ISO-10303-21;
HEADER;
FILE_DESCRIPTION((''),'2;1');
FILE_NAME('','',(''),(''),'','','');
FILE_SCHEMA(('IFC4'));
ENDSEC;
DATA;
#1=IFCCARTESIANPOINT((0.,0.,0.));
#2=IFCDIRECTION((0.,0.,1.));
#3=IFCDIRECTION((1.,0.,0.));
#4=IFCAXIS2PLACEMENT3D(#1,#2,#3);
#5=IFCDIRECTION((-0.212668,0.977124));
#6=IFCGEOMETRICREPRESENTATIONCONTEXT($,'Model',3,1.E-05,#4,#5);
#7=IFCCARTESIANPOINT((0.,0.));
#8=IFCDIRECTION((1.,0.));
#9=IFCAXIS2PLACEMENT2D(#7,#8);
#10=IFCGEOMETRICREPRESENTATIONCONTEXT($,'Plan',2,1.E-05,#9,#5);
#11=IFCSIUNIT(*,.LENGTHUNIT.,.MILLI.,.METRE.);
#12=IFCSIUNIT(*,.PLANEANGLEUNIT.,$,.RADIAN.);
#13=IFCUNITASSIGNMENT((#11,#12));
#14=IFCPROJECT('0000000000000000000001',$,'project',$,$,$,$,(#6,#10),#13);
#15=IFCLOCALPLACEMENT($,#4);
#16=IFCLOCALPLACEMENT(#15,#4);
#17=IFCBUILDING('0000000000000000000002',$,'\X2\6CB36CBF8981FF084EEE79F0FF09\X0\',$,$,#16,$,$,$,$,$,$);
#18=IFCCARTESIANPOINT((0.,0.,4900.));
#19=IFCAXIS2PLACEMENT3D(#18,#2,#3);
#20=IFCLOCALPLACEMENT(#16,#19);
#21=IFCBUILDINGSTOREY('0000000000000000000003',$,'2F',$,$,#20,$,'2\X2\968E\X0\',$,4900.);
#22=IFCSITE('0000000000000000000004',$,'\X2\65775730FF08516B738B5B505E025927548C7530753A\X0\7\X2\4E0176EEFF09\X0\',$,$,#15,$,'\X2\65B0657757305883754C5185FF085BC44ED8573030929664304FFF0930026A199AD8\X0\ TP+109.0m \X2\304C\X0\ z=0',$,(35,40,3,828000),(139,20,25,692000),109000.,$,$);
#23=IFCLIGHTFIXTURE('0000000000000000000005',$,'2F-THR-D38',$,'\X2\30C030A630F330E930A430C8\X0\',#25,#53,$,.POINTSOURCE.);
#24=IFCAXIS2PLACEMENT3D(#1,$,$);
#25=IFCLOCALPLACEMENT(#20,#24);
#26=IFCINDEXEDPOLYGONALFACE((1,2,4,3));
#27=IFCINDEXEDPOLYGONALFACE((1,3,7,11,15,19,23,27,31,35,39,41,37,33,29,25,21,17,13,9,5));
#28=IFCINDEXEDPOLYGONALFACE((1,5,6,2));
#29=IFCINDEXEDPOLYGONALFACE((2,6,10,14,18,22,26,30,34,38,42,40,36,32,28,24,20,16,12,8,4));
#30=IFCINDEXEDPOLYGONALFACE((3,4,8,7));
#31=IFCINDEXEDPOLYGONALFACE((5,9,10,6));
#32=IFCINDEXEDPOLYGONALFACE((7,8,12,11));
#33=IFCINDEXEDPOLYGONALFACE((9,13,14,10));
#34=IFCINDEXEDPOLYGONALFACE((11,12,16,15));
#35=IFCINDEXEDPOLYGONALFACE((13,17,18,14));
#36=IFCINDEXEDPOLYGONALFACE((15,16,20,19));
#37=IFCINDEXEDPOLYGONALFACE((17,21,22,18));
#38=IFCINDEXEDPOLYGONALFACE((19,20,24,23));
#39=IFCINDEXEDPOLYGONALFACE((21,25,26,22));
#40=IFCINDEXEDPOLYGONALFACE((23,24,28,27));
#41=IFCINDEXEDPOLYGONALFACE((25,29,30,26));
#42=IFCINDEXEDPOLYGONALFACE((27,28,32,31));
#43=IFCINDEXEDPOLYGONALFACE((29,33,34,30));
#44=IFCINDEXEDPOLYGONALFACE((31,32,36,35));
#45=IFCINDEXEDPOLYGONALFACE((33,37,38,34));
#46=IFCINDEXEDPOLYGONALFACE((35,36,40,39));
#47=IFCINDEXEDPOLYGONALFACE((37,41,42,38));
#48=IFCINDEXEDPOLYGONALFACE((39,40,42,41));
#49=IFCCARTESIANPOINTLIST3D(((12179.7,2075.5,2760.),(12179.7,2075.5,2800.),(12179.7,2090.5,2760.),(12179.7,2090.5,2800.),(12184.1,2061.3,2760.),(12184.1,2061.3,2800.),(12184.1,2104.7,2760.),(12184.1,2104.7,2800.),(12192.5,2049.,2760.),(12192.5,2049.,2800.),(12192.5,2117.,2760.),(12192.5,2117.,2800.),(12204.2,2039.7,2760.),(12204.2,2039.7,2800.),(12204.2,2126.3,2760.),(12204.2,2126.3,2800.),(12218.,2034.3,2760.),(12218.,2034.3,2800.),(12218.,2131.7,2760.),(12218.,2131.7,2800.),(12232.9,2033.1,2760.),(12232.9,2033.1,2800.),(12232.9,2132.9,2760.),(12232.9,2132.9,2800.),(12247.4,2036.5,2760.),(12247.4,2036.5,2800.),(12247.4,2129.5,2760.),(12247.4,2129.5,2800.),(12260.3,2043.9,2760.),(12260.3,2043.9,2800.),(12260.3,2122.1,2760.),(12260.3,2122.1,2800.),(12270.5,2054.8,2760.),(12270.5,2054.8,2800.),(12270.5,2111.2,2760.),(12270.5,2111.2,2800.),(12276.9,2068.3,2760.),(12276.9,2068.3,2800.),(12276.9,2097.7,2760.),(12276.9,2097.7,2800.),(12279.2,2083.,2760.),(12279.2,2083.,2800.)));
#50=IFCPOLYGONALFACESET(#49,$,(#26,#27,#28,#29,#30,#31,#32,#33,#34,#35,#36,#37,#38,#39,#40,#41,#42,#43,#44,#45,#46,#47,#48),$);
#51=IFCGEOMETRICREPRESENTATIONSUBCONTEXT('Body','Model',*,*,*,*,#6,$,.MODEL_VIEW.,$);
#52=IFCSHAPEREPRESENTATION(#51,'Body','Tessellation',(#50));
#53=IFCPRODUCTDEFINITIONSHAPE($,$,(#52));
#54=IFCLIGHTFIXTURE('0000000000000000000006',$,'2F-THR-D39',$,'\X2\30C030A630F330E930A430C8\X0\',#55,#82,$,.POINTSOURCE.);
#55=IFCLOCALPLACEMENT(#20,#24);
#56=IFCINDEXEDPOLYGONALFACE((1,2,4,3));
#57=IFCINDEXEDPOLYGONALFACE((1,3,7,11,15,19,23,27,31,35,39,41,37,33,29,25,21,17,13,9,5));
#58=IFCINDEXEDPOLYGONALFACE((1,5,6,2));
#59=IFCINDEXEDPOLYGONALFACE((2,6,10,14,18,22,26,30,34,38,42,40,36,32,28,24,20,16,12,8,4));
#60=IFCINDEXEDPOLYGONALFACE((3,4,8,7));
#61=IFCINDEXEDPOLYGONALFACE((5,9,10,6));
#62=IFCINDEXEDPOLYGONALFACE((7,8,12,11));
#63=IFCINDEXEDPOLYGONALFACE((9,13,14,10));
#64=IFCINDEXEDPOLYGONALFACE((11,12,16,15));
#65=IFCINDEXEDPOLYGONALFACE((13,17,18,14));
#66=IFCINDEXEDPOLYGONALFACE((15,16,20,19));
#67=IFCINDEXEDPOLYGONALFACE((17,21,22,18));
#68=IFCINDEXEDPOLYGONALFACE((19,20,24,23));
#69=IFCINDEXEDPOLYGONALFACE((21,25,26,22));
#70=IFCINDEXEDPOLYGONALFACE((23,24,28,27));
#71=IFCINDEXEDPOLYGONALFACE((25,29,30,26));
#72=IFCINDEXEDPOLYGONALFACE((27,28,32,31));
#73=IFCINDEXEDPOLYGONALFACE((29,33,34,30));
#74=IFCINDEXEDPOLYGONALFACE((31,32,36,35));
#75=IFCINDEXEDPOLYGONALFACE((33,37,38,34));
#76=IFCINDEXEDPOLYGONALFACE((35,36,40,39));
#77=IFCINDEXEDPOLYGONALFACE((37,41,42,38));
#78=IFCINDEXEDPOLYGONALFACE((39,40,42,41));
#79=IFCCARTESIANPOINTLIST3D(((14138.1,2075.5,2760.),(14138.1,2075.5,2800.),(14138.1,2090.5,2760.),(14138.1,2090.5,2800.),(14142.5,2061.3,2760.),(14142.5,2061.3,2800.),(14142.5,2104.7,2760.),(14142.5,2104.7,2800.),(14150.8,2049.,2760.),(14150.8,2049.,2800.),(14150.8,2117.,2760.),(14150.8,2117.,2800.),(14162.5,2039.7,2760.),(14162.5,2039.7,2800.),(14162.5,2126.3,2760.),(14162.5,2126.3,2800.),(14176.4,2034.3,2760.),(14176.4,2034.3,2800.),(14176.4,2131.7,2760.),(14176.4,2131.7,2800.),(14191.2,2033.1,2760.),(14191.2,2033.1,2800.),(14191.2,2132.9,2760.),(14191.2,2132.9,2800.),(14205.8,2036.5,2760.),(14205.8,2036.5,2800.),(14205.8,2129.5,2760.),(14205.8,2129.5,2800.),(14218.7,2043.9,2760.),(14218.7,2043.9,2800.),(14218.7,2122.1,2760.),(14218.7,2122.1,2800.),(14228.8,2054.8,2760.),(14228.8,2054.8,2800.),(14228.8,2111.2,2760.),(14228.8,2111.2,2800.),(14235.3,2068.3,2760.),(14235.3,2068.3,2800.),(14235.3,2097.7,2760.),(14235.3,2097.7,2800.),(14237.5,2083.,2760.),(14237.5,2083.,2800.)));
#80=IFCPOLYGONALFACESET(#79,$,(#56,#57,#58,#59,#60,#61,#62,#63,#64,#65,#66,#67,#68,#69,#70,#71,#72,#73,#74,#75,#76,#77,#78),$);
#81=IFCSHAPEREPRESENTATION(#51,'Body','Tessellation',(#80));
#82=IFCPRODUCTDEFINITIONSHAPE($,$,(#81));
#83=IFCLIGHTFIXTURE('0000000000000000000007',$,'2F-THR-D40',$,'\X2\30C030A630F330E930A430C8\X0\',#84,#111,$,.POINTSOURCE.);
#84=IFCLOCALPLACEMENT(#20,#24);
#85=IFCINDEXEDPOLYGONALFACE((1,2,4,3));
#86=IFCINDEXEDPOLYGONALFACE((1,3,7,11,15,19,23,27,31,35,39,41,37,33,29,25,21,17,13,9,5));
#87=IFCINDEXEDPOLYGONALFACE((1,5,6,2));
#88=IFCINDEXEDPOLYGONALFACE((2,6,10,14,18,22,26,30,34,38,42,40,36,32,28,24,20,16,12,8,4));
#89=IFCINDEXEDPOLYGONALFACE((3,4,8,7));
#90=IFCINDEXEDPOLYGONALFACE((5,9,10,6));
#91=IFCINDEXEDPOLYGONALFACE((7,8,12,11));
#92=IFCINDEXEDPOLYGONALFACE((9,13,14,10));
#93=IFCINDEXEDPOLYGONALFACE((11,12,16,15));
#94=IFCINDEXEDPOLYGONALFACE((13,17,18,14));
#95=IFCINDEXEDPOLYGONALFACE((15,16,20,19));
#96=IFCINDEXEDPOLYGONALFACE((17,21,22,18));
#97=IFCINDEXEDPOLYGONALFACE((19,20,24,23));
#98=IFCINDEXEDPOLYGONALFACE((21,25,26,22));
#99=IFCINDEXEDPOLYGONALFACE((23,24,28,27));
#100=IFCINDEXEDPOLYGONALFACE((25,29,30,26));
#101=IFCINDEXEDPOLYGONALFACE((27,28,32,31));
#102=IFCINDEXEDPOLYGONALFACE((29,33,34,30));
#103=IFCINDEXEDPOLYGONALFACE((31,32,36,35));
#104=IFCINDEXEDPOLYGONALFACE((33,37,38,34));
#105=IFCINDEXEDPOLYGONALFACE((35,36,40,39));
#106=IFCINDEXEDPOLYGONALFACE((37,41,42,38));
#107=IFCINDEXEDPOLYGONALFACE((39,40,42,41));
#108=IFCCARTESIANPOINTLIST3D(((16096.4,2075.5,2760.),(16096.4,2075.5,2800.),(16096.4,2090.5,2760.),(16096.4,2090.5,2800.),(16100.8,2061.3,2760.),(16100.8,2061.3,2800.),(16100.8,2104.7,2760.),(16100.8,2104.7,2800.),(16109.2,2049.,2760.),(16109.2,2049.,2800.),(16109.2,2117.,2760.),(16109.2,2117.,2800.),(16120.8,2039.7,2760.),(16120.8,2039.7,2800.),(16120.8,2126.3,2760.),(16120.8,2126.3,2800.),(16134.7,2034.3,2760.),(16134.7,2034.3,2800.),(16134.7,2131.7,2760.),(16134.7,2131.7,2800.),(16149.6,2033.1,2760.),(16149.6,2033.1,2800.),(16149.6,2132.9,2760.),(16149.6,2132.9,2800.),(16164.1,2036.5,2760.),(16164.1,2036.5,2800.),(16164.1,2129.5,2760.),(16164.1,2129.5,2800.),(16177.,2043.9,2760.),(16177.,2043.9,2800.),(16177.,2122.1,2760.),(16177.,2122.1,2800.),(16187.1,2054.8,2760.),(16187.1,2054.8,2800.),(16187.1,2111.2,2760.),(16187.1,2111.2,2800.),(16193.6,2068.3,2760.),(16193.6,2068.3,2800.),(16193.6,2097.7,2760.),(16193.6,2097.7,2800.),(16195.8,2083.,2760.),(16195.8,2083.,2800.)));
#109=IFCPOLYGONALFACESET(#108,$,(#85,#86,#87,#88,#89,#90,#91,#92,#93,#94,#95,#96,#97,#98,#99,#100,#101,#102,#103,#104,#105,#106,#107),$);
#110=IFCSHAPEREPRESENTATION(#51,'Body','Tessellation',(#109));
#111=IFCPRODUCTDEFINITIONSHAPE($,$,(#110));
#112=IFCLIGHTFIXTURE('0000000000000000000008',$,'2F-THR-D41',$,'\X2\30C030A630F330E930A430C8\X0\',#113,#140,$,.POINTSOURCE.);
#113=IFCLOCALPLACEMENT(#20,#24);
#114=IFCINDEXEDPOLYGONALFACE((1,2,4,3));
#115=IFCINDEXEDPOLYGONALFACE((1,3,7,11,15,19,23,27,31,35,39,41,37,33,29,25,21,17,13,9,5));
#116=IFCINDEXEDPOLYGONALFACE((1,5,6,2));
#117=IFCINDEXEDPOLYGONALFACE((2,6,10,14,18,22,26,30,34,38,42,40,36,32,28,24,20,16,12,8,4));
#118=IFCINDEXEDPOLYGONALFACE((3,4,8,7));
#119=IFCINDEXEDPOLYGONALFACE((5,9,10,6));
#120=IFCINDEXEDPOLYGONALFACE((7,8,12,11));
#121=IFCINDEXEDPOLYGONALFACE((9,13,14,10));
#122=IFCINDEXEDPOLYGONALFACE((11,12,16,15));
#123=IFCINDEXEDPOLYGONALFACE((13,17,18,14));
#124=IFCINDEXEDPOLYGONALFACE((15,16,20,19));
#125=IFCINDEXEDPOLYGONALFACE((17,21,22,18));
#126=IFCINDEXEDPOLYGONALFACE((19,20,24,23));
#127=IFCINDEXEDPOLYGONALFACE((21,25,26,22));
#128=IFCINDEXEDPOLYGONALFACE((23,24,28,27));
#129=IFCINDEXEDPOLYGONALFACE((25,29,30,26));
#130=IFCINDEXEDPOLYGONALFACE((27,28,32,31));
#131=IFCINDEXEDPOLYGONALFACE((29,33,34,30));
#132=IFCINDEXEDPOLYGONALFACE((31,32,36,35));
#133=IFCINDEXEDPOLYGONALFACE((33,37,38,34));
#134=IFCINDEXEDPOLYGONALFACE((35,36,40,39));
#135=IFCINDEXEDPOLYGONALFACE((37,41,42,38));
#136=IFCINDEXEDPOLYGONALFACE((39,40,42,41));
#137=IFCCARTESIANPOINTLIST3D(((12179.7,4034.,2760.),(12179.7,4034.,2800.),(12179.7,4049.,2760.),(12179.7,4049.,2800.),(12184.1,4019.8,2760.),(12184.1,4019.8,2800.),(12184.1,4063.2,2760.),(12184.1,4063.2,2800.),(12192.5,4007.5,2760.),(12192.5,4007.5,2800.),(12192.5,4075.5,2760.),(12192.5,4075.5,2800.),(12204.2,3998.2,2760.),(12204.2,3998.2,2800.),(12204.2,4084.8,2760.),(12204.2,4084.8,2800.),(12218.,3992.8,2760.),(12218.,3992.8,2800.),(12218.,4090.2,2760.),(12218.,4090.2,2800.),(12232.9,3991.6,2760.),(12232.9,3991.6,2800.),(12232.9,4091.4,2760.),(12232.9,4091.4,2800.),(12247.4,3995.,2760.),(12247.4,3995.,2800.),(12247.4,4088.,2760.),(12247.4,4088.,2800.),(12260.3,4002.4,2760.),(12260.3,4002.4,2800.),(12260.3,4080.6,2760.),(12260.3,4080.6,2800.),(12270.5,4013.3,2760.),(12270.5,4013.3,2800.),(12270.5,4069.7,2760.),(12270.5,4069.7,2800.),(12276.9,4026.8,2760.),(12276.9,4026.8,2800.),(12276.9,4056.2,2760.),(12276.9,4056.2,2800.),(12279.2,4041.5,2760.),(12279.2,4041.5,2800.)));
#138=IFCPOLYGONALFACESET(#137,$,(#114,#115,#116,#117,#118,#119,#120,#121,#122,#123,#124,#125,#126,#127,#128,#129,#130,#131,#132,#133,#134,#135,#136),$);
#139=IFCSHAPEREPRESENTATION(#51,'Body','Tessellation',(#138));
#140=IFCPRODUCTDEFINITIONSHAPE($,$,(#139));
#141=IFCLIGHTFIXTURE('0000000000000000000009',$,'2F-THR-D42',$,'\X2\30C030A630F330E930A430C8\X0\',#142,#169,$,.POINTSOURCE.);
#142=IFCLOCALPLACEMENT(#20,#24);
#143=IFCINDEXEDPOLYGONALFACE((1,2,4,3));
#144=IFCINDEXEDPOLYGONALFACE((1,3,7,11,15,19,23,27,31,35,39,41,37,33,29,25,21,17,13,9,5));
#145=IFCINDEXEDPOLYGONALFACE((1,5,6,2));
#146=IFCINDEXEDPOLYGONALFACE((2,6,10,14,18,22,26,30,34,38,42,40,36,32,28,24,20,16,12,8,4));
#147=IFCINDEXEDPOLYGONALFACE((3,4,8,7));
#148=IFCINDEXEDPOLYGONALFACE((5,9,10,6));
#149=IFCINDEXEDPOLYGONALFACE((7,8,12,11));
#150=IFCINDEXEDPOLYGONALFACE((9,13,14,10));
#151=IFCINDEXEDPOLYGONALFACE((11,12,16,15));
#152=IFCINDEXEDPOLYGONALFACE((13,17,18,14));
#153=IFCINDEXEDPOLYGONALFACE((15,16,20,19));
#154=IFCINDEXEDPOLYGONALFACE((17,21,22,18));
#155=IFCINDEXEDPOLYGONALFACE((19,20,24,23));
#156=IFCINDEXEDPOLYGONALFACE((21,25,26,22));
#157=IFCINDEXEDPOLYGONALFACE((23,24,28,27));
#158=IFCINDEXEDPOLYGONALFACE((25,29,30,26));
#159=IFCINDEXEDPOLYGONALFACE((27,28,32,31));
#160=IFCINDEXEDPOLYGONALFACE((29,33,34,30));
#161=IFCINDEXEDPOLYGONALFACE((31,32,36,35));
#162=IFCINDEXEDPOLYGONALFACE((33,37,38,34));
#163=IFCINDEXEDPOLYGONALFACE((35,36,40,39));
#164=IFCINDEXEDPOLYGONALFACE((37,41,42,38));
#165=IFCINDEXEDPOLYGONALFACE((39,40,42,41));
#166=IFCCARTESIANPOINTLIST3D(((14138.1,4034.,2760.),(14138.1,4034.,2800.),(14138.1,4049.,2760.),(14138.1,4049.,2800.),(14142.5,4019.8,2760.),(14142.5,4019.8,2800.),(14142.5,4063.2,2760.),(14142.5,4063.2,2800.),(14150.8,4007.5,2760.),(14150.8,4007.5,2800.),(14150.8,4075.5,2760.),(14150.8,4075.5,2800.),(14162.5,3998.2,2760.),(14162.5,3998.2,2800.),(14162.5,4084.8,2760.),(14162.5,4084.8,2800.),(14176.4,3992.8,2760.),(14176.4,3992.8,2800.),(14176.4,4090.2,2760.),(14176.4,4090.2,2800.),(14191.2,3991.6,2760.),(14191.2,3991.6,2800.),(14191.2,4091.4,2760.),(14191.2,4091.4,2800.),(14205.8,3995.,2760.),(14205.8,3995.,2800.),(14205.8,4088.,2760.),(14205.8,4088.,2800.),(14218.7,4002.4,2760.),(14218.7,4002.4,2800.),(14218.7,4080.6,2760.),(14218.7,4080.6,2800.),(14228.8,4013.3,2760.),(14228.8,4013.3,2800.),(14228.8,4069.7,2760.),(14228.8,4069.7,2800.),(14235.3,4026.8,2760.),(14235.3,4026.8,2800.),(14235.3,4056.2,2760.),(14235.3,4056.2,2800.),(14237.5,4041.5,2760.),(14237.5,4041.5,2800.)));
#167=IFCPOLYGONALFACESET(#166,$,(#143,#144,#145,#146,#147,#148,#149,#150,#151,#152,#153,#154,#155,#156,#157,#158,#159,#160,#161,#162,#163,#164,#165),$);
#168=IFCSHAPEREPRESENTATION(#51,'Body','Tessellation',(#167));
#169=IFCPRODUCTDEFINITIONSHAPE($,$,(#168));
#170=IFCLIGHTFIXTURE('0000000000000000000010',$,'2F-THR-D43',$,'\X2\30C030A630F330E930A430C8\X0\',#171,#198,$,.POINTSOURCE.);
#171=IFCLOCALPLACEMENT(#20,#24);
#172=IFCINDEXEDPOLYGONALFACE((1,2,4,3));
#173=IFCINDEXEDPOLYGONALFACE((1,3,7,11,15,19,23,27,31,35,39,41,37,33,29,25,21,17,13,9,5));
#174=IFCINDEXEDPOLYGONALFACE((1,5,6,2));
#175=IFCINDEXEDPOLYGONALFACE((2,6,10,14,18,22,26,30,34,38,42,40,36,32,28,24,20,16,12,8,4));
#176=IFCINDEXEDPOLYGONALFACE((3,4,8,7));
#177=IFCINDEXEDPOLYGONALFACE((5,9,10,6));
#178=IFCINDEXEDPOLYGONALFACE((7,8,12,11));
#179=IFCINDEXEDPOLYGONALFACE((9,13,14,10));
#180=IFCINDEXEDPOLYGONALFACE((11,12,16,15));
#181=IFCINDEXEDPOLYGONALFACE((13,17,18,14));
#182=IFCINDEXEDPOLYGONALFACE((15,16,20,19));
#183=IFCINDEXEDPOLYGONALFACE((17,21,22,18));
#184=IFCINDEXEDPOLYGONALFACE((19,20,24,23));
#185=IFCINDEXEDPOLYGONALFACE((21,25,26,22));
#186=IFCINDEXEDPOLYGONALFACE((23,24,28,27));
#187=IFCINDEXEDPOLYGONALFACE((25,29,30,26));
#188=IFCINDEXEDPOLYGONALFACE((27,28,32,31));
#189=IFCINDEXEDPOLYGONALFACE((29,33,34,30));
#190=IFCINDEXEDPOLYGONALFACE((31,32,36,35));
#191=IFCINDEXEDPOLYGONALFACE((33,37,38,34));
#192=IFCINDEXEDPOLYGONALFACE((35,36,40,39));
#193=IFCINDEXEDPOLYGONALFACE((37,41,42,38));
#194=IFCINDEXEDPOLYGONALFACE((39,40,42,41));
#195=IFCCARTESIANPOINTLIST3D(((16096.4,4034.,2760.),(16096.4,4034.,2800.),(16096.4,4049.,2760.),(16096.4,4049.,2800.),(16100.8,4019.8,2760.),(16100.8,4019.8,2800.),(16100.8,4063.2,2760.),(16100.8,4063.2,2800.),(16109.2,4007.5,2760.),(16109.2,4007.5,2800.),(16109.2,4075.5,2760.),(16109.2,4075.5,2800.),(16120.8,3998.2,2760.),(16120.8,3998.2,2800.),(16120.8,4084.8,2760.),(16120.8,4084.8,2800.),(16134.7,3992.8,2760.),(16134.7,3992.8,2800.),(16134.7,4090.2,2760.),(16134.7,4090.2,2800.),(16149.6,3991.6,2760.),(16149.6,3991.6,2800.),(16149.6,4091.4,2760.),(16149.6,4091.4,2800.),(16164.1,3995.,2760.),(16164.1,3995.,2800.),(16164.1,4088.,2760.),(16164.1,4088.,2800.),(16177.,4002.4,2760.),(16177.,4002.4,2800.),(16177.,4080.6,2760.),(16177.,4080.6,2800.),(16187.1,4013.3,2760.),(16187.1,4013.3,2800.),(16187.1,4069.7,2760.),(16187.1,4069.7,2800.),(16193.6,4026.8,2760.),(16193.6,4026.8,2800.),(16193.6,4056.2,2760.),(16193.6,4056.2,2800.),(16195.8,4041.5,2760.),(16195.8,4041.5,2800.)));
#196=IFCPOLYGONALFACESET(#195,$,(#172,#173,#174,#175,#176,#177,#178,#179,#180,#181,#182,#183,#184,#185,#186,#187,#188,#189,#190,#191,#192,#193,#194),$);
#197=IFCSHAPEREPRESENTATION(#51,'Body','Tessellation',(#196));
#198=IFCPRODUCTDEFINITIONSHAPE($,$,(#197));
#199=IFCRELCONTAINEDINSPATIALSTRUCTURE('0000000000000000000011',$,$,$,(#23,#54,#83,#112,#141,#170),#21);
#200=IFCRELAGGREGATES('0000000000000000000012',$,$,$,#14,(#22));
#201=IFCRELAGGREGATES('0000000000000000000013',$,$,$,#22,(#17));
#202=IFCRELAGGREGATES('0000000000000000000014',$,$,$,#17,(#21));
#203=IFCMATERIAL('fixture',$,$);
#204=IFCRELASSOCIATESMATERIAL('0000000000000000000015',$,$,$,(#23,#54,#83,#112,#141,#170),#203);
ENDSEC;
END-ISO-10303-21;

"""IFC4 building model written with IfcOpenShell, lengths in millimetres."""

from ifc_helpers import new_model, si_unit, direction, frame, frame_2d, origin_with_axes, origin_2d_with_axis, place, context, subcontext, project, spatial, circle, extrude, material, element, save


model = new_model("IFC4")

# Units and contexts
model_context = context("Model", 3, precision=1e-05, world=origin_with_axes(), true_north=direction((-0.212668, 0.977124)))
plan_context = context("Plan", 2, precision=1e-05, world=origin_2d_with_axis(), true_north=direction((-0.212668, 0.977124)))
body_context = subcontext(model_context, "Body", "Model", "MODEL_VIEW")
ifc_project = project(units=[si_unit("LENGTHUNIT", "METRE", prefix="MILLI"), si_unit("PLANEANGLEUNIT", "RADIAN")], contexts=[model_context, plan_context])

# Site, building, storey
site_placement = place(None, origin_with_axes())
site = spatial("IfcSite", under=ifc_project, at=site_placement, Name="敷地（八王子市大和田町7丁目）", LongName="新敷地境界内（寄付地を除く）。標高 TP+109.0m が z=0", RefLatitude=(35, 40, 3, 828000), RefLongitude=(139, 20, 25, 692000), RefElevation=109000.0)
building_placement = place(site_placement, origin_with_axes())
building = spatial("IfcBuilding", under=site, at=building_placement, Name="河沿要（仮称）")
storey_placement = place(building_placement, frame((0.0, 0.0, 4900.0), z_axis=(0.0, 0.0, 1.0), x_axis=(1.0, 0.0, 0.0)))
storey = spatial("IfcBuildingStorey", under=building, at=storey_placement, Name="2F", LongName="2階", Elevation=4900.0)

# Light fixtures
ifc_material = material(Name="fixture")
light_fixture_1_placement = place(storey_placement, origin_with_axes())
element("IfcLightFixture", 1, at=light_fixture_1_placement, inside=storey, material=ifc_material, Name="2F-THR-D38", ObjectType="ダウンライト", PredefinedType="POINTSOURCE", context=body_context, shape_type="SweptSolid", body=[
    extrude(circle(Radius=50.0, at=frame_2d((12229.2, 2083.0))), frame((0.0, 0.0, 2760.0)), (0.0, 0.0, 1.0), 40.0),
])
light_fixture_2_placement = place(storey_placement, origin_with_axes())
element("IfcLightFixture", 2, at=light_fixture_2_placement, inside=storey, material=ifc_material, Name="2F-THR-D39", ObjectType="ダウンライト", PredefinedType="POINTSOURCE", context=body_context, shape_type="SweptSolid", body=[
    extrude(circle(Radius=50.0, at=frame_2d((14187.5, 2083.0))), frame((0.0, 0.0, 2760.0)), (0.0, 0.0, 1.0), 40.0),
])
light_fixture_3_placement = place(storey_placement, origin_with_axes())
element("IfcLightFixture", 3, at=light_fixture_3_placement, inside=storey, material=ifc_material, Name="2F-THR-D40", ObjectType="ダウンライト", PredefinedType="POINTSOURCE", context=body_context, shape_type="SweptSolid", body=[
    extrude(circle(Radius=50.0, at=frame_2d((16145.8, 2083.0))), frame((0.0, 0.0, 2760.0)), (0.0, 0.0, 1.0), 40.0),
])
light_fixture_4_placement = place(storey_placement, origin_with_axes())
element("IfcLightFixture", 4, at=light_fixture_4_placement, inside=storey, material=ifc_material, Name="2F-THR-D41", ObjectType="ダウンライト", PredefinedType="POINTSOURCE", context=body_context, shape_type="SweptSolid", body=[
    extrude(circle(Radius=50.0, at=frame_2d((12229.2, 4041.5))), frame((0.0, 0.0, 2760.0)), (0.0, 0.0, 1.0), 40.0),
])
light_fixture_5_placement = place(storey_placement, origin_with_axes())
element("IfcLightFixture", 5, at=light_fixture_5_placement, inside=storey, material=ifc_material, Name="2F-THR-D42", ObjectType="ダウンライト", PredefinedType="POINTSOURCE", context=body_context, shape_type="SweptSolid", body=[
    extrude(circle(Radius=50.0, at=frame_2d((14187.5, 4041.5))), frame((0.0, 0.0, 2760.0)), (0.0, 0.0, 1.0), 40.0),
])
light_fixture_6_placement = place(storey_placement, origin_with_axes())
element("IfcLightFixture", 6, at=light_fixture_6_placement, inside=storey, material=ifc_material, Name="2F-THR-D43", ObjectType="ダウンライト", PredefinedType="POINTSOURCE", context=body_context, shape_type="SweptSolid", body=[
    extrude(circle(Radius=50.0, at=frame_2d((16145.8, 4041.5))), frame((0.0, 0.0, 2760.0)), (0.0, 0.0, 1.0), 40.0),
])

save(model, "model.ifc")
